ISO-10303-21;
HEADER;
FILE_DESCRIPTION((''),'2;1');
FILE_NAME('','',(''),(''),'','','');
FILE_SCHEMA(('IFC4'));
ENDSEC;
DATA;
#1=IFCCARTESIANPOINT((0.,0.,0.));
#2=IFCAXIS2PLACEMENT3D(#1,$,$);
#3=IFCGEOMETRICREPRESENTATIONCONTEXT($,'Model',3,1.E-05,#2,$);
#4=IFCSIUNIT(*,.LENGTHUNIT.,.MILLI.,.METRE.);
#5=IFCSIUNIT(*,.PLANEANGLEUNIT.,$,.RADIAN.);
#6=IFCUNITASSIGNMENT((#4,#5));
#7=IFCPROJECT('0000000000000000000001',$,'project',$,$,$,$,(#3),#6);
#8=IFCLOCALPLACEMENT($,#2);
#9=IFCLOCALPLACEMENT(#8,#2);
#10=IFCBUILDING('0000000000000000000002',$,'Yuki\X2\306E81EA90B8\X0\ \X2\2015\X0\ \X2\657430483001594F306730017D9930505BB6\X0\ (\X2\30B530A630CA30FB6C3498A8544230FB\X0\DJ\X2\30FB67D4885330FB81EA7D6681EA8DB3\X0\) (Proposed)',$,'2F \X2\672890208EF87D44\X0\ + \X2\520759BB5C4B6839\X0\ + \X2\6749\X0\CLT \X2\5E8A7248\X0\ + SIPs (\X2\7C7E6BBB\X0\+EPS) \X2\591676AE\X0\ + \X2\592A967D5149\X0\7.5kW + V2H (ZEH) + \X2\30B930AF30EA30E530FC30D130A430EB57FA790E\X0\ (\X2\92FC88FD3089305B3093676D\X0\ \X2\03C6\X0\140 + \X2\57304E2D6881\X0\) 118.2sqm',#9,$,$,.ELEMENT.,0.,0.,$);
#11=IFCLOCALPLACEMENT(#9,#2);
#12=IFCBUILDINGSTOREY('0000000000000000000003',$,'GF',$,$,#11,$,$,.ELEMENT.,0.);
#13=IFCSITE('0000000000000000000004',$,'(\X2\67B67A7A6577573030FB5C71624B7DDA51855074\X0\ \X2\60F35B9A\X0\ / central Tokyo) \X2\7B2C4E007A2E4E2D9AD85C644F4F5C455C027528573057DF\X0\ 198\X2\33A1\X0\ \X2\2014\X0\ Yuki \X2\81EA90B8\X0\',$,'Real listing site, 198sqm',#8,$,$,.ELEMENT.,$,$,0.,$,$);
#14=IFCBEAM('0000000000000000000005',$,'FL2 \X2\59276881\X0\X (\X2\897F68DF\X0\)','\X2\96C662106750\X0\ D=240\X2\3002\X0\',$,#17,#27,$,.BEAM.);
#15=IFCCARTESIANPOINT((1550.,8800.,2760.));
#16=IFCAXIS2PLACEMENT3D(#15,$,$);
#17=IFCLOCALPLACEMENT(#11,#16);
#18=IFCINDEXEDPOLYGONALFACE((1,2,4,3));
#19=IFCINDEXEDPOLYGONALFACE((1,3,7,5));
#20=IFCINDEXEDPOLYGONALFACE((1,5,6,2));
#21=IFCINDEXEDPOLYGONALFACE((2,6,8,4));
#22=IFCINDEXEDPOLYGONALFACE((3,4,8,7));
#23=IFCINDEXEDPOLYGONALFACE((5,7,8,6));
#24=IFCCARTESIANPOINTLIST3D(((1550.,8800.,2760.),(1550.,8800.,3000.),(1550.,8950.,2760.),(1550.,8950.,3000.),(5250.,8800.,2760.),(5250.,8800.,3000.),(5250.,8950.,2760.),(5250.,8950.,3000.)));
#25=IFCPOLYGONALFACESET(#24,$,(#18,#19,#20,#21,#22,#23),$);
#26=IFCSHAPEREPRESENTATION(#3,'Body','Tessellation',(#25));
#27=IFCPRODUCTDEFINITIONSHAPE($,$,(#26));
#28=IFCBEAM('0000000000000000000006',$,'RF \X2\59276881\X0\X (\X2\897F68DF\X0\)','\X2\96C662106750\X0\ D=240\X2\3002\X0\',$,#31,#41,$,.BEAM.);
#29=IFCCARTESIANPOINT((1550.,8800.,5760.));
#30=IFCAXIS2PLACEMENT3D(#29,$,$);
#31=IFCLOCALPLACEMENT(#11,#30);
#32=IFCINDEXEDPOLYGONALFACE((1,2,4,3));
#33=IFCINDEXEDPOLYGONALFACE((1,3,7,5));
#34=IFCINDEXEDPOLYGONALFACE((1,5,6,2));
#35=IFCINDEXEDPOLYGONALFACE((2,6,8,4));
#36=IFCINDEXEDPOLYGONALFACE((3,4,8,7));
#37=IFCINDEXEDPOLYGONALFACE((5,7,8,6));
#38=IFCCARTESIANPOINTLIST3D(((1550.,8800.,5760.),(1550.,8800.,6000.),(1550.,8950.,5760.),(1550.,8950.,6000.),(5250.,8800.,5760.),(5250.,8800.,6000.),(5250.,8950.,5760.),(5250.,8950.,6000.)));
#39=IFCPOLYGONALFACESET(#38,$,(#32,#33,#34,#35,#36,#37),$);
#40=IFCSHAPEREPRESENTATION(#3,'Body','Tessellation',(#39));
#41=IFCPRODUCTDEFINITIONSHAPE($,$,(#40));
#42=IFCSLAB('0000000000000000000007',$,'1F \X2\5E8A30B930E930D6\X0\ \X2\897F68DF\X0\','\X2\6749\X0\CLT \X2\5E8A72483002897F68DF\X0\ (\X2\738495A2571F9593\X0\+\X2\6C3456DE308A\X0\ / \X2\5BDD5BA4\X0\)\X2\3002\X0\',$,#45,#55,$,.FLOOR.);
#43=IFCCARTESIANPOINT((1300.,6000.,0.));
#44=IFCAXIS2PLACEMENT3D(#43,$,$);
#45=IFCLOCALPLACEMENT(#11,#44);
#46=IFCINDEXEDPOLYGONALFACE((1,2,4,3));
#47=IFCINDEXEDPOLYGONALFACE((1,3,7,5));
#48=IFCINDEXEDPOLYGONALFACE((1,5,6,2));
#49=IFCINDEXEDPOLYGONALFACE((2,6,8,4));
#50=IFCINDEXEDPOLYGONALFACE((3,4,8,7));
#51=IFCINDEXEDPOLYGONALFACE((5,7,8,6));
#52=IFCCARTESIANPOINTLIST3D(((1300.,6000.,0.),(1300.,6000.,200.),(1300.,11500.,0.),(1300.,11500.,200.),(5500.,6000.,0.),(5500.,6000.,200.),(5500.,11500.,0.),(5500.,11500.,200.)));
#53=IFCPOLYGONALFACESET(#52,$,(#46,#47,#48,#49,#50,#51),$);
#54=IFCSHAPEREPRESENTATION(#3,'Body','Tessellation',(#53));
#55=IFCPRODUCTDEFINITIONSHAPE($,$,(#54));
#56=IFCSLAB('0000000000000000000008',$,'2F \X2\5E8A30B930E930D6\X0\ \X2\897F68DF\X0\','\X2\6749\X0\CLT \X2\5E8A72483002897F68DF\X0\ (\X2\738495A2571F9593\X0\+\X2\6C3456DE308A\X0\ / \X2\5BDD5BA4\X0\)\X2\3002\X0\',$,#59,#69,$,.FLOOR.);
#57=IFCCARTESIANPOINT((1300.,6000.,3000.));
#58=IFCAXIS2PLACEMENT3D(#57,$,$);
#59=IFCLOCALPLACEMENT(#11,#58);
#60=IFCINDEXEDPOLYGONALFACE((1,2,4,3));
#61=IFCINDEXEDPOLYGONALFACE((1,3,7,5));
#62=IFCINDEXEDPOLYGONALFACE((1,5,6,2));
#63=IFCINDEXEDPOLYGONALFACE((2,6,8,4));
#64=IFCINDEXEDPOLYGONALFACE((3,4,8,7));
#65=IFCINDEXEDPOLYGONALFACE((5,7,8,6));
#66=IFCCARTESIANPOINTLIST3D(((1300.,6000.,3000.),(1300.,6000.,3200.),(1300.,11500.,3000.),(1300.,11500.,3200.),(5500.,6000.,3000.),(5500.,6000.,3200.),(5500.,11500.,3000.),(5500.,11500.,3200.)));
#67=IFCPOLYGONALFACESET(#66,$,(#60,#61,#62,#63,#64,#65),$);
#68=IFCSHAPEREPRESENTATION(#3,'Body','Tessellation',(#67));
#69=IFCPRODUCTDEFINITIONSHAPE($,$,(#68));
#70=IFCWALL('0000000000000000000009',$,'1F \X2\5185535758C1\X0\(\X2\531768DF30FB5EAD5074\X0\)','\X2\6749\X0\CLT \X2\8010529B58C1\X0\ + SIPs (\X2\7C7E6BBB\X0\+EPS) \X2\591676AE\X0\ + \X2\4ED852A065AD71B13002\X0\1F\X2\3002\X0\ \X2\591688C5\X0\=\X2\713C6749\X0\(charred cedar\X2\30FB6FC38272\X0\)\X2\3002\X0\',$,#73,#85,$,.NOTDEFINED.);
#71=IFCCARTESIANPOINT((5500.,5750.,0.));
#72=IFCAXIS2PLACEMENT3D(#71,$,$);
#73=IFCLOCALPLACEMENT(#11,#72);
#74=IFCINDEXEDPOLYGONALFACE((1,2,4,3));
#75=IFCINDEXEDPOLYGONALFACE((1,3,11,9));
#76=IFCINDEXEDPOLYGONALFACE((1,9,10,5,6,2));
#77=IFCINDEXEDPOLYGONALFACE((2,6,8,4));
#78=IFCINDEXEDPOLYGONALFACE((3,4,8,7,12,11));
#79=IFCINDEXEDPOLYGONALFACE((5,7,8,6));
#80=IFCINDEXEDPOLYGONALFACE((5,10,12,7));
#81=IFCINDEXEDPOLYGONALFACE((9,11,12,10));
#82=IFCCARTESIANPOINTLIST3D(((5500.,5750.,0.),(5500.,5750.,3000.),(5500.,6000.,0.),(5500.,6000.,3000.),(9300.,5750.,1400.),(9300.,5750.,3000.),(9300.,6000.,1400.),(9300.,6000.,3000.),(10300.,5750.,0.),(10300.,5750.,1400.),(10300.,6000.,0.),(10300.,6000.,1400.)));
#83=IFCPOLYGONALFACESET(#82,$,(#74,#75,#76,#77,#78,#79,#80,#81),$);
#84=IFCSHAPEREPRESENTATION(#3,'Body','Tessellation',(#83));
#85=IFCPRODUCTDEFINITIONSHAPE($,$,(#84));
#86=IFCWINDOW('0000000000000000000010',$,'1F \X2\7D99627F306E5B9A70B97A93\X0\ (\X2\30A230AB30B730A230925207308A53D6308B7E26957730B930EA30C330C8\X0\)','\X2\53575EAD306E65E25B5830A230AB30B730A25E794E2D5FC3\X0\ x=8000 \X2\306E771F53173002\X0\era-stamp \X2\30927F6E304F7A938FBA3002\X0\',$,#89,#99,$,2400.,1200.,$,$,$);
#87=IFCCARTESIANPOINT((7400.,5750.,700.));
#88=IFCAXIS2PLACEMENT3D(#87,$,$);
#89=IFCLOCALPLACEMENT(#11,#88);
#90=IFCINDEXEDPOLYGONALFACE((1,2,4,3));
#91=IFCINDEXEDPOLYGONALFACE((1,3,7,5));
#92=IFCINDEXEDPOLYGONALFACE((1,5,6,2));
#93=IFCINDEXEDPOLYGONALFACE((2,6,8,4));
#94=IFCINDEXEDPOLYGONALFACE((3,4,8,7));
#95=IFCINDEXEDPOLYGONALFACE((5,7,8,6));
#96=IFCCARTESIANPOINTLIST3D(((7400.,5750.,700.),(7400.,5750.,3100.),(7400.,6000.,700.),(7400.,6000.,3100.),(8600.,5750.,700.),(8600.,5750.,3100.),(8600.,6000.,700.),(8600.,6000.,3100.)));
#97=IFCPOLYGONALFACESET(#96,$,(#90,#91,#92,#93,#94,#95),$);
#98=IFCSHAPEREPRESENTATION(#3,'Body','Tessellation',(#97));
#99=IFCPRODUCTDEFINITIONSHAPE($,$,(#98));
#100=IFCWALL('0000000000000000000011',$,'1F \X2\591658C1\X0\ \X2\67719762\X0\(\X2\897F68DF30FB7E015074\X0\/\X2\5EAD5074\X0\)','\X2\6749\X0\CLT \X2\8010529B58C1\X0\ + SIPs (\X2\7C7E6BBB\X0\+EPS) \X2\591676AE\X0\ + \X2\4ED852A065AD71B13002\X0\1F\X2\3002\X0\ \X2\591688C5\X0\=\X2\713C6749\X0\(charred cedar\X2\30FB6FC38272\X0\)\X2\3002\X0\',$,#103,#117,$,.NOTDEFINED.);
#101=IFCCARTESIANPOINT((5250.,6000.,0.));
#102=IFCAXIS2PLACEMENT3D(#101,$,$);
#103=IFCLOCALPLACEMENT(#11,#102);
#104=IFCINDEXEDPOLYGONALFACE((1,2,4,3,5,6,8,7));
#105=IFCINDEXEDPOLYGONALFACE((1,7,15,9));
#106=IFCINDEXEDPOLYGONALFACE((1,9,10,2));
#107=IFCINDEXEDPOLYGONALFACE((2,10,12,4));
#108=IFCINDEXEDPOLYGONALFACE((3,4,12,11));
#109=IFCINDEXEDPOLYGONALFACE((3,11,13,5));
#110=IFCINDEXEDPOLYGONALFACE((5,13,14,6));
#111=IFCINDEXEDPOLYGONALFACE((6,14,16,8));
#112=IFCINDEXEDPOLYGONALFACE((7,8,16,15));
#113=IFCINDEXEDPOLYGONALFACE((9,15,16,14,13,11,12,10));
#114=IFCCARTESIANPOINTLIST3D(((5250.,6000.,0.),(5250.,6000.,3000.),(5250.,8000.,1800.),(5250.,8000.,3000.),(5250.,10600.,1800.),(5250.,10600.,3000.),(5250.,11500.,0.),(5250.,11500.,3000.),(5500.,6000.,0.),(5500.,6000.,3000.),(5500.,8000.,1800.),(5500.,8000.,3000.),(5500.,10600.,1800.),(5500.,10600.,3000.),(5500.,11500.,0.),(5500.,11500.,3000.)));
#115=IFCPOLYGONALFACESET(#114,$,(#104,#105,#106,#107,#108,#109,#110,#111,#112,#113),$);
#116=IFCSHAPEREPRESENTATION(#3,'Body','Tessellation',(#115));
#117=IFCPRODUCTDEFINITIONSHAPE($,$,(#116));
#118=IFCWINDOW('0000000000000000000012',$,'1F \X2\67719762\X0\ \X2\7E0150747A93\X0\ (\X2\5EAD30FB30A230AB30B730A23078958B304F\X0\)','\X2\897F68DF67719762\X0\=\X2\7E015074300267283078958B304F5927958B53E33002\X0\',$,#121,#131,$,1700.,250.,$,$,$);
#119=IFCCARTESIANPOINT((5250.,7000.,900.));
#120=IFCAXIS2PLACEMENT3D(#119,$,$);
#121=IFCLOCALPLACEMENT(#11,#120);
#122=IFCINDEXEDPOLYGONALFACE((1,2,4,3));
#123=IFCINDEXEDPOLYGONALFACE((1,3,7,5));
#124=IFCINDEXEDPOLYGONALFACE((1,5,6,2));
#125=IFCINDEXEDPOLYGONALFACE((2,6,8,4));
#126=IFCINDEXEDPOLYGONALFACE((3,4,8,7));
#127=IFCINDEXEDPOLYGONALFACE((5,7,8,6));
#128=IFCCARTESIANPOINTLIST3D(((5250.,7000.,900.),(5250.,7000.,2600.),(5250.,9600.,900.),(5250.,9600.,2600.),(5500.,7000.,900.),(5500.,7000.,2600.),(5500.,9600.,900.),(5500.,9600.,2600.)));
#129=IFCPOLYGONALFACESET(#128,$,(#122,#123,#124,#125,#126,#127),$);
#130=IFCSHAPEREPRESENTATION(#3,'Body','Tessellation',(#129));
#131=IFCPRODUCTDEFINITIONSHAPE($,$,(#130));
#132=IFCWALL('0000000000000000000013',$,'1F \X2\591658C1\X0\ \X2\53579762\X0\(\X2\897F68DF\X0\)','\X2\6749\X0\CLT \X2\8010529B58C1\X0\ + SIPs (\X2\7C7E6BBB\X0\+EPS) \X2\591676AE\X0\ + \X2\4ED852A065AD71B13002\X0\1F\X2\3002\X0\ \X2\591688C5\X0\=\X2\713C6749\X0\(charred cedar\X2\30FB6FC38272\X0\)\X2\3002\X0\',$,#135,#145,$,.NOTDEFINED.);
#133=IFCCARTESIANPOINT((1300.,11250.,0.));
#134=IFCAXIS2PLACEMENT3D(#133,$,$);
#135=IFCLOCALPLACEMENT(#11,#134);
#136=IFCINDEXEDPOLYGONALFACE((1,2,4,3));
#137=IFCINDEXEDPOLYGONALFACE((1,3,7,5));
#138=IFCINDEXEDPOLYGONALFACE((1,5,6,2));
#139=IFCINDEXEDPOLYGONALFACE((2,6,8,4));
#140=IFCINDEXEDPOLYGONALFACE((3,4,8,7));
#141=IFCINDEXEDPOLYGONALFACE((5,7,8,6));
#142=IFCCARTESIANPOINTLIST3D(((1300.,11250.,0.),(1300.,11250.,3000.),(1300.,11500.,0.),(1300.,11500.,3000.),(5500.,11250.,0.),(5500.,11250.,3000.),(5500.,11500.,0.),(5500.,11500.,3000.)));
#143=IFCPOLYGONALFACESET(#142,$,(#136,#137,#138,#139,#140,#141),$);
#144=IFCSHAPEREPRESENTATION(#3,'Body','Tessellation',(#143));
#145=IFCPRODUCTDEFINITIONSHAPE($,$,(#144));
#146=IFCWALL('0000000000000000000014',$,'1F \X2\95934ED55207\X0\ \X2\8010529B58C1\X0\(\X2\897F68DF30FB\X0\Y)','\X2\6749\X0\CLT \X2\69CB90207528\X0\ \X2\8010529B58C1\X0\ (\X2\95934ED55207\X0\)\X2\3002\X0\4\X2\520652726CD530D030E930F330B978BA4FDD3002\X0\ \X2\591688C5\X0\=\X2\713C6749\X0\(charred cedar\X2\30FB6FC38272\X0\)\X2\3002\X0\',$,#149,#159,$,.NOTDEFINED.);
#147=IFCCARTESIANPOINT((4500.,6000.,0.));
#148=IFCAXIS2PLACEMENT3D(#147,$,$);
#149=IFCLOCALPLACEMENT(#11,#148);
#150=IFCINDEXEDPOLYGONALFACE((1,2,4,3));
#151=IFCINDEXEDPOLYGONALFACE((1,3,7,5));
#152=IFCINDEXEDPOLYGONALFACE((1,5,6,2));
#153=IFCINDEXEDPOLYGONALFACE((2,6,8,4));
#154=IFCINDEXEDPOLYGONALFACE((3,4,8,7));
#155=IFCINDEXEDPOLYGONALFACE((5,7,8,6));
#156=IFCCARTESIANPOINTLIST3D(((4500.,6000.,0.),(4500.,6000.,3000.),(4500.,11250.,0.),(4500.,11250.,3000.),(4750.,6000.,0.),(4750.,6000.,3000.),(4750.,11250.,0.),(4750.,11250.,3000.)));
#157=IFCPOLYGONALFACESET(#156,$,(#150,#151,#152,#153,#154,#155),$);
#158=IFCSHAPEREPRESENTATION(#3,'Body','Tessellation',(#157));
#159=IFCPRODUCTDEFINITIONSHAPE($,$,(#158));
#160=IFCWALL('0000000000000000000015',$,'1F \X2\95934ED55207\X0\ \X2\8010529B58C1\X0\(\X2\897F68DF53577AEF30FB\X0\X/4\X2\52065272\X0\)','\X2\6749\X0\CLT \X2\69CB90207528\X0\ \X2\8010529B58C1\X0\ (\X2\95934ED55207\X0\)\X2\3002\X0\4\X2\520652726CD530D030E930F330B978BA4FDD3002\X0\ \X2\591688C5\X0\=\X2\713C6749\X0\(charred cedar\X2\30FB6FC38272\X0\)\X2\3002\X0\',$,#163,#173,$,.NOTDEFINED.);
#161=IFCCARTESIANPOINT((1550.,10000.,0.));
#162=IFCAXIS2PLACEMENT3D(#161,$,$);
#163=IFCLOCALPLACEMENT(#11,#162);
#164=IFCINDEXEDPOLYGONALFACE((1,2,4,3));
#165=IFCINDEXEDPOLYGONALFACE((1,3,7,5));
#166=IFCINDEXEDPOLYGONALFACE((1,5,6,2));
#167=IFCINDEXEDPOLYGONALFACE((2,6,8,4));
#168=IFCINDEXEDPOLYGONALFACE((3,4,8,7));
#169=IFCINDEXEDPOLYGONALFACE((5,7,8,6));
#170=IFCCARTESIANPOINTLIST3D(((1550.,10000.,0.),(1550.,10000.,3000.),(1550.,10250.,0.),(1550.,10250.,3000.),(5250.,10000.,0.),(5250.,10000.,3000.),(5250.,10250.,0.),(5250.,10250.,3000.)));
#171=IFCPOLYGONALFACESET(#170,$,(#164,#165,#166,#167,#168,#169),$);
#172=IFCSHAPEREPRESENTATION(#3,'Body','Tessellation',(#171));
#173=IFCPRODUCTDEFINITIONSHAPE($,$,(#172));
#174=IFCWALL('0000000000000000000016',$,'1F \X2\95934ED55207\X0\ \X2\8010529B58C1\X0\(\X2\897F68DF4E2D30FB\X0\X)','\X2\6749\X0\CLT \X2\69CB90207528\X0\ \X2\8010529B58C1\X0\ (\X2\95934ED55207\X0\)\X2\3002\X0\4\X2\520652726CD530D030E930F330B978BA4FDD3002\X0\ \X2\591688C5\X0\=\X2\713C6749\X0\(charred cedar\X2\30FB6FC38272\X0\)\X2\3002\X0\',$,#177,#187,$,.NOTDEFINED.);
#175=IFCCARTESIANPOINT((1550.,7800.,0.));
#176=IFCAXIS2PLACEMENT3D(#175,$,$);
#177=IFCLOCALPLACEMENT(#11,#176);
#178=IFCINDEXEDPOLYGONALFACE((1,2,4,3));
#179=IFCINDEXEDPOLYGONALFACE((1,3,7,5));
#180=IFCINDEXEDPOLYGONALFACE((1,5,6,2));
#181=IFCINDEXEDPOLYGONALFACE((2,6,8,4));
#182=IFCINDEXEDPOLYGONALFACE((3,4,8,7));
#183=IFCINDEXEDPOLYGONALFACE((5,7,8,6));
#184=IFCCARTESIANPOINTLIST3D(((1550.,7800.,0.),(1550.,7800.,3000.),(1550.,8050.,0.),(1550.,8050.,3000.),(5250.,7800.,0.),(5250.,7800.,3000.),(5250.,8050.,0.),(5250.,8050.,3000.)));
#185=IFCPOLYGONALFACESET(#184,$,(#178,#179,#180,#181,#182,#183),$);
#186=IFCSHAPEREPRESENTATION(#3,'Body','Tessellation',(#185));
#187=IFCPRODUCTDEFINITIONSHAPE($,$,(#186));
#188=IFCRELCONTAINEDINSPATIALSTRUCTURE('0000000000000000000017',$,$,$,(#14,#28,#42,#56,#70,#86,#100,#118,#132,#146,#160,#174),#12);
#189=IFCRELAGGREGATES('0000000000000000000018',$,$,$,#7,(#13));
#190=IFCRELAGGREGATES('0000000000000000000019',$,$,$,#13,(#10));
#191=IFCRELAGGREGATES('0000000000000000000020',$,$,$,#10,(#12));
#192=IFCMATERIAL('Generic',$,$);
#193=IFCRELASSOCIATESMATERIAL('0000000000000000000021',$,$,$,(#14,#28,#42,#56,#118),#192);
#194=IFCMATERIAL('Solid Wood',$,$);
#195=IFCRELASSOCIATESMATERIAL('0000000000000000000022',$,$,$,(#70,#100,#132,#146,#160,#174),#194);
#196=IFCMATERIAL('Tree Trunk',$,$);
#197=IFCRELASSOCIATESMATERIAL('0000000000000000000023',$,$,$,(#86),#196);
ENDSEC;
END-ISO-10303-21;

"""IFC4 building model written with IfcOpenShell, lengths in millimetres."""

from ifc_helpers import new_model, si_unit, frame, frame_2d, origin, place, context, project, spatial, rectangle, extrude, material, element, fill, save


model = new_model("IFC4")

# Units and contexts
model_context = context("Model", 3, precision=1e-05, world=origin())
ifc_project = project(units=[si_unit("LENGTHUNIT", "METRE", prefix="MILLI"), si_unit("PLANEANGLEUNIT", "RADIAN")], contexts=[model_context])

# Site, building, storey
site_placement = place(None, origin())
site = spatial("IfcSite", under=ifc_project, at=site_placement, Name="(架空敷地・山手線内側 想定 / central Tokyo) 第一種中高層住居専用地域 198㎡ — Yuki 自邸", ObjectType="Real listing site, 198sqm", CompositionType="ELEMENT", RefElevation=0.0)
building_placement = place(site_placement, origin())
building = spatial("IfcBuilding", under=site, at=building_placement, Name="Yukiの自邸 ― 整え、奏で、継ぐ家 (サウナ・水風呂・DJ・柔術・自給自足) (Proposed)", ObjectType="2F 木造軸組 + 切妻屋根 + 杉CLT 床版 + SIPs (籾殻+EPS) 外皮 + 太陽光7.5kW + V2H (ZEH) + スクリューパイル基礎 (鋼製らせん杭 φ140 + 地中梁) 118.2sqm", CompositionType="ELEMENT", ElevationOfRefHeight=0.0, ElevationOfTerrain=0.0)
storey_placement = place(building_placement, origin())
storey = spatial("IfcBuildingStorey", under=building, at=storey_placement, Name="GF", CompositionType="ELEMENT", Elevation=0.0)

# Shared definitions
ifc_material_1 = material(Name="Generic")

# Beams
beam_1_placement = place(storey_placement, frame((1550.0, 8800.0, 2760.0)))
element("IfcBeam", 1, at=beam_1_placement, inside=storey, material=ifc_material_1, Name="FL2 大梁X (西棟)", Description="集成材 D=240。", PredefinedType="BEAM", context=model_context, shape_type="SweptSolid", body=[
    extrude(rectangle(XDim=3700.0, YDim=150.0, at=frame_2d((1850.0, 75.0))), frame((1550.0, 8800.0, 2760.0)), (0.0, 0.0, 1.0), 240.0),
])
beam_2_placement = place(storey_placement, frame((1550.0, 8800.0, 5760.0)))
element("IfcBeam", 2, at=beam_2_placement, inside=storey, material=ifc_material_1, Name="RF 大梁X (西棟)", Description="集成材 D=240。", PredefinedType="BEAM", context=model_context, shape_type="SweptSolid", body=[
    extrude(rectangle(XDim=3700.0, YDim=150.0, at=frame_2d((1850.0, 75.0))), frame((1550.0, 8800.0, 5760.0)), (0.0, 0.0, 1.0), 240.0),
])

# Slabs
slab_1_placement = place(storey_placement, frame((1300.0, 6000.0, 0.0)))
element("IfcSlab", 3, at=slab_1_placement, inside=storey, material=ifc_material_1, Name="1F 床スラブ 西棟", Description="杉CLT 床版。西棟 (玄関土間+水回り / 寝室)。", PredefinedType="FLOOR", context=model_context, shape_type="SweptSolid", body=[
    extrude(rectangle(XDim=4200.0, YDim=5500.0, at=frame_2d((2100.0, 2750.0))), frame((1300.0, 6000.0, 0.0)), (0.0, 0.0, 1.0), 200.0),
])
slab_2_placement = place(storey_placement, frame((1300.0, 6000.0, 3000.0)))
element("IfcSlab", 4, at=slab_2_placement, inside=storey, material=ifc_material_1, Name="2F 床スラブ 西棟", Description="杉CLT 床版。西棟 (玄関土間+水回り / 寝室)。", PredefinedType="FLOOR", context=model_context, shape_type="SweptSolid", body=[
    extrude(rectangle(XDim=4200.0, YDim=5500.0, at=frame_2d((2100.0, 2750.0))), frame((1300.0, 6000.0, 3000.0)), (0.0, 0.0, 1.0), 200.0),
])

# Walls, openings, windows
ifc_material_2 = material(Name="Solid Wood")
wall_1_placement = place(storey_placement, frame((5500.0, 5750.0, 0.0)))
wall_1 = element("IfcWall", 5, at=wall_1_placement, inside=storey, material=ifc_material_2, Name="1F 内南壁(北棟・庭側)", Description="杉CLT 耐力壁 + SIPs (籾殻+EPS) 外皮 + 付加断熱。1F。 外装=焼杉(charred cedar・濃色)。", PredefinedType="NOTDEFINED", context=model_context, shape_type="SweptSolid", body=[
    extrude(rectangle(XDim=4800.0, YDim=250.0, at=frame_2d((2400.0, 125.0))), frame((5500.0, 5750.0, 0.0)), (0.0, 0.0, 1.0), 3000.0),
])
opening_1_placement = place(storey_placement, frame((7400.0, 5750.0, 700.0)))
opening_1 = element("IfcOpeningElement", 6, at=opening_1_placement, cuts=wall_1, PredefinedType="NOTDEFINED", context=model_context, shape_type="SweptSolid", body=[
    extrude(rectangle(XDim=1200.0, YDim=250.0, at=frame_2d((600.0, 125.0))), frame((7400.0, 5750.0, 700.0)), (0.0, 0.0, 1.0), 2400.0),
])
ifc_material_3 = material(Name="Tree Trunk")
window_1_placement = place(storey_placement, frame((7400.0, 5750.0, 700.0)))
window_1 = element("IfcWindow", 7, at=window_1_placement, inside=storey, material=ifc_material_3, Name="1F 継承の定点窓 (アカシアを切り取る縦長スリット)", Description="南庭の既存アカシア幹中心 x=8000 の真北。era-stamp を置く窓辺。", OverallHeight=2400.0, OverallWidth=1200.0, context=model_context, shape_type="SweptSolid", body=[
    extrude(rectangle(XDim=1200.0, YDim=250.0, at=frame_2d((600.0, 125.0))), frame((7400.0, 5750.0, 700.0)), (0.0, 0.0, 1.0), 2400.0),
])
fill(opening_1, window_1)
wall_2_placement = place(storey_placement, frame((5250.0, 6000.0, 0.0)))
wall_2 = element("IfcWall", 8, at=wall_2_placement, inside=storey, material=ifc_material_2, Name="1F 外壁 東面(西棟・縁側/庭側)", Description="杉CLT 耐力壁 + SIPs (籾殻+EPS) 外皮 + 付加断熱。1F。 外装=焼杉(charred cedar・濃色)。", PredefinedType="NOTDEFINED", context=model_context, shape_type="SweptSolid", body=[
    extrude(rectangle(XDim=250.0, YDim=5500.0, at=frame_2d((125.0, 2750.0))), frame((5250.0, 6000.0, 0.0)), (0.0, 0.0, 1.0), 3000.0),
])
opening_2_placement = place(storey_placement, frame((5250.0, 7000.0, 900.0)))
opening_2 = element("IfcOpeningElement", 9, at=opening_2_placement, cuts=wall_2, PredefinedType="NOTDEFINED", context=model_context, shape_type="SweptSolid", body=[
    extrude(rectangle(XDim=250.0, YDim=2600.0, at=frame_2d((125.0, 1300.0))), frame((5250.0, 7000.0, 900.0)), (0.0, 0.0, 1.0), 1700.0),
])
window_2_placement = place(storey_placement, frame((5250.0, 7000.0, 900.0)))
window_2 = element("IfcWindow", 10, at=window_2_placement, inside=storey, material=ifc_material_1, Name="1F 東面 縁側窓 (庭・アカシアへ開く)", Description="西棟東面=縁側。木へ開く大開口。", OverallHeight=1700.0, OverallWidth=250.0, context=model_context, shape_type="SweptSolid", body=[
    extrude(rectangle(XDim=250.0, YDim=2600.0, at=frame_2d((125.0, 1300.0))), frame((5250.0, 7000.0, 900.0)), (0.0, 0.0, 1.0), 1700.0),
])
fill(opening_2, window_2)

# Walls
wall_3_placement = place(storey_placement, frame((1300.0, 11250.0, 0.0)))
element("IfcWall", 11, at=wall_3_placement, inside=storey, material=ifc_material_2, Name="1F 外壁 南面(西棟)", Description="杉CLT 耐力壁 + SIPs (籾殻+EPS) 外皮 + 付加断熱。1F。 外装=焼杉(charred cedar・濃色)。", PredefinedType="NOTDEFINED", context=model_context, shape_type="SweptSolid", body=[
    extrude(rectangle(XDim=4200.0, YDim=250.0, at=frame_2d((2100.0, 125.0))), frame((1300.0, 11250.0, 0.0)), (0.0, 0.0, 1.0), 3000.0),
])
wall_4_placement = place(storey_placement, frame((4500.0, 6000.0, 0.0)))
element("IfcWall", 12, at=wall_4_placement, inside=storey, material=ifc_material_2, Name="1F 間仕切 耐力壁(西棟・Y)", Description="杉CLT 構造用 耐力壁 (間仕切)。4分割法バランス確保。 外装=焼杉(charred cedar・濃色)。", PredefinedType="NOTDEFINED", context=model_context, shape_type="SweptSolid", body=[
    extrude(rectangle(XDim=250.0, YDim=5250.0, at=frame_2d((125.0, 2625.0))), frame((4500.0, 6000.0, 0.0)), (0.0, 0.0, 1.0), 3000.0),
])
wall_5_placement = place(storey_placement, frame((1550.0, 10000.0, 0.0)))
element("IfcWall", 13, at=wall_5_placement, inside=storey, material=ifc_material_2, Name="1F 間仕切 耐力壁(西棟南端・X/4分割)", Description="杉CLT 構造用 耐力壁 (間仕切)。4分割法バランス確保。 外装=焼杉(charred cedar・濃色)。", PredefinedType="NOTDEFINED", context=model_context, shape_type="SweptSolid", body=[
    extrude(rectangle(XDim=3700.0, YDim=250.0, at=frame_2d((1850.0, 125.0))), frame((1550.0, 10000.0, 0.0)), (0.0, 0.0, 1.0), 3000.0),
])
wall_6_placement = place(storey_placement, frame((1550.0, 7800.0, 0.0)))
element("IfcWall", 14, at=wall_6_placement, inside=storey, material=ifc_material_2, Name="1F 間仕切 耐力壁(西棟中・X)", Description="杉CLT 構造用 耐力壁 (間仕切)。4分割法バランス確保。 外装=焼杉(charred cedar・濃色)。", PredefinedType="NOTDEFINED", context=model_context, shape_type="SweptSolid", body=[
    extrude(rectangle(XDim=3700.0, YDim=250.0, at=frame_2d((1850.0, 125.0))), frame((1550.0, 7800.0, 0.0)), (0.0, 0.0, 1.0), 3000.0),
])

save(model, "model.ifc")
